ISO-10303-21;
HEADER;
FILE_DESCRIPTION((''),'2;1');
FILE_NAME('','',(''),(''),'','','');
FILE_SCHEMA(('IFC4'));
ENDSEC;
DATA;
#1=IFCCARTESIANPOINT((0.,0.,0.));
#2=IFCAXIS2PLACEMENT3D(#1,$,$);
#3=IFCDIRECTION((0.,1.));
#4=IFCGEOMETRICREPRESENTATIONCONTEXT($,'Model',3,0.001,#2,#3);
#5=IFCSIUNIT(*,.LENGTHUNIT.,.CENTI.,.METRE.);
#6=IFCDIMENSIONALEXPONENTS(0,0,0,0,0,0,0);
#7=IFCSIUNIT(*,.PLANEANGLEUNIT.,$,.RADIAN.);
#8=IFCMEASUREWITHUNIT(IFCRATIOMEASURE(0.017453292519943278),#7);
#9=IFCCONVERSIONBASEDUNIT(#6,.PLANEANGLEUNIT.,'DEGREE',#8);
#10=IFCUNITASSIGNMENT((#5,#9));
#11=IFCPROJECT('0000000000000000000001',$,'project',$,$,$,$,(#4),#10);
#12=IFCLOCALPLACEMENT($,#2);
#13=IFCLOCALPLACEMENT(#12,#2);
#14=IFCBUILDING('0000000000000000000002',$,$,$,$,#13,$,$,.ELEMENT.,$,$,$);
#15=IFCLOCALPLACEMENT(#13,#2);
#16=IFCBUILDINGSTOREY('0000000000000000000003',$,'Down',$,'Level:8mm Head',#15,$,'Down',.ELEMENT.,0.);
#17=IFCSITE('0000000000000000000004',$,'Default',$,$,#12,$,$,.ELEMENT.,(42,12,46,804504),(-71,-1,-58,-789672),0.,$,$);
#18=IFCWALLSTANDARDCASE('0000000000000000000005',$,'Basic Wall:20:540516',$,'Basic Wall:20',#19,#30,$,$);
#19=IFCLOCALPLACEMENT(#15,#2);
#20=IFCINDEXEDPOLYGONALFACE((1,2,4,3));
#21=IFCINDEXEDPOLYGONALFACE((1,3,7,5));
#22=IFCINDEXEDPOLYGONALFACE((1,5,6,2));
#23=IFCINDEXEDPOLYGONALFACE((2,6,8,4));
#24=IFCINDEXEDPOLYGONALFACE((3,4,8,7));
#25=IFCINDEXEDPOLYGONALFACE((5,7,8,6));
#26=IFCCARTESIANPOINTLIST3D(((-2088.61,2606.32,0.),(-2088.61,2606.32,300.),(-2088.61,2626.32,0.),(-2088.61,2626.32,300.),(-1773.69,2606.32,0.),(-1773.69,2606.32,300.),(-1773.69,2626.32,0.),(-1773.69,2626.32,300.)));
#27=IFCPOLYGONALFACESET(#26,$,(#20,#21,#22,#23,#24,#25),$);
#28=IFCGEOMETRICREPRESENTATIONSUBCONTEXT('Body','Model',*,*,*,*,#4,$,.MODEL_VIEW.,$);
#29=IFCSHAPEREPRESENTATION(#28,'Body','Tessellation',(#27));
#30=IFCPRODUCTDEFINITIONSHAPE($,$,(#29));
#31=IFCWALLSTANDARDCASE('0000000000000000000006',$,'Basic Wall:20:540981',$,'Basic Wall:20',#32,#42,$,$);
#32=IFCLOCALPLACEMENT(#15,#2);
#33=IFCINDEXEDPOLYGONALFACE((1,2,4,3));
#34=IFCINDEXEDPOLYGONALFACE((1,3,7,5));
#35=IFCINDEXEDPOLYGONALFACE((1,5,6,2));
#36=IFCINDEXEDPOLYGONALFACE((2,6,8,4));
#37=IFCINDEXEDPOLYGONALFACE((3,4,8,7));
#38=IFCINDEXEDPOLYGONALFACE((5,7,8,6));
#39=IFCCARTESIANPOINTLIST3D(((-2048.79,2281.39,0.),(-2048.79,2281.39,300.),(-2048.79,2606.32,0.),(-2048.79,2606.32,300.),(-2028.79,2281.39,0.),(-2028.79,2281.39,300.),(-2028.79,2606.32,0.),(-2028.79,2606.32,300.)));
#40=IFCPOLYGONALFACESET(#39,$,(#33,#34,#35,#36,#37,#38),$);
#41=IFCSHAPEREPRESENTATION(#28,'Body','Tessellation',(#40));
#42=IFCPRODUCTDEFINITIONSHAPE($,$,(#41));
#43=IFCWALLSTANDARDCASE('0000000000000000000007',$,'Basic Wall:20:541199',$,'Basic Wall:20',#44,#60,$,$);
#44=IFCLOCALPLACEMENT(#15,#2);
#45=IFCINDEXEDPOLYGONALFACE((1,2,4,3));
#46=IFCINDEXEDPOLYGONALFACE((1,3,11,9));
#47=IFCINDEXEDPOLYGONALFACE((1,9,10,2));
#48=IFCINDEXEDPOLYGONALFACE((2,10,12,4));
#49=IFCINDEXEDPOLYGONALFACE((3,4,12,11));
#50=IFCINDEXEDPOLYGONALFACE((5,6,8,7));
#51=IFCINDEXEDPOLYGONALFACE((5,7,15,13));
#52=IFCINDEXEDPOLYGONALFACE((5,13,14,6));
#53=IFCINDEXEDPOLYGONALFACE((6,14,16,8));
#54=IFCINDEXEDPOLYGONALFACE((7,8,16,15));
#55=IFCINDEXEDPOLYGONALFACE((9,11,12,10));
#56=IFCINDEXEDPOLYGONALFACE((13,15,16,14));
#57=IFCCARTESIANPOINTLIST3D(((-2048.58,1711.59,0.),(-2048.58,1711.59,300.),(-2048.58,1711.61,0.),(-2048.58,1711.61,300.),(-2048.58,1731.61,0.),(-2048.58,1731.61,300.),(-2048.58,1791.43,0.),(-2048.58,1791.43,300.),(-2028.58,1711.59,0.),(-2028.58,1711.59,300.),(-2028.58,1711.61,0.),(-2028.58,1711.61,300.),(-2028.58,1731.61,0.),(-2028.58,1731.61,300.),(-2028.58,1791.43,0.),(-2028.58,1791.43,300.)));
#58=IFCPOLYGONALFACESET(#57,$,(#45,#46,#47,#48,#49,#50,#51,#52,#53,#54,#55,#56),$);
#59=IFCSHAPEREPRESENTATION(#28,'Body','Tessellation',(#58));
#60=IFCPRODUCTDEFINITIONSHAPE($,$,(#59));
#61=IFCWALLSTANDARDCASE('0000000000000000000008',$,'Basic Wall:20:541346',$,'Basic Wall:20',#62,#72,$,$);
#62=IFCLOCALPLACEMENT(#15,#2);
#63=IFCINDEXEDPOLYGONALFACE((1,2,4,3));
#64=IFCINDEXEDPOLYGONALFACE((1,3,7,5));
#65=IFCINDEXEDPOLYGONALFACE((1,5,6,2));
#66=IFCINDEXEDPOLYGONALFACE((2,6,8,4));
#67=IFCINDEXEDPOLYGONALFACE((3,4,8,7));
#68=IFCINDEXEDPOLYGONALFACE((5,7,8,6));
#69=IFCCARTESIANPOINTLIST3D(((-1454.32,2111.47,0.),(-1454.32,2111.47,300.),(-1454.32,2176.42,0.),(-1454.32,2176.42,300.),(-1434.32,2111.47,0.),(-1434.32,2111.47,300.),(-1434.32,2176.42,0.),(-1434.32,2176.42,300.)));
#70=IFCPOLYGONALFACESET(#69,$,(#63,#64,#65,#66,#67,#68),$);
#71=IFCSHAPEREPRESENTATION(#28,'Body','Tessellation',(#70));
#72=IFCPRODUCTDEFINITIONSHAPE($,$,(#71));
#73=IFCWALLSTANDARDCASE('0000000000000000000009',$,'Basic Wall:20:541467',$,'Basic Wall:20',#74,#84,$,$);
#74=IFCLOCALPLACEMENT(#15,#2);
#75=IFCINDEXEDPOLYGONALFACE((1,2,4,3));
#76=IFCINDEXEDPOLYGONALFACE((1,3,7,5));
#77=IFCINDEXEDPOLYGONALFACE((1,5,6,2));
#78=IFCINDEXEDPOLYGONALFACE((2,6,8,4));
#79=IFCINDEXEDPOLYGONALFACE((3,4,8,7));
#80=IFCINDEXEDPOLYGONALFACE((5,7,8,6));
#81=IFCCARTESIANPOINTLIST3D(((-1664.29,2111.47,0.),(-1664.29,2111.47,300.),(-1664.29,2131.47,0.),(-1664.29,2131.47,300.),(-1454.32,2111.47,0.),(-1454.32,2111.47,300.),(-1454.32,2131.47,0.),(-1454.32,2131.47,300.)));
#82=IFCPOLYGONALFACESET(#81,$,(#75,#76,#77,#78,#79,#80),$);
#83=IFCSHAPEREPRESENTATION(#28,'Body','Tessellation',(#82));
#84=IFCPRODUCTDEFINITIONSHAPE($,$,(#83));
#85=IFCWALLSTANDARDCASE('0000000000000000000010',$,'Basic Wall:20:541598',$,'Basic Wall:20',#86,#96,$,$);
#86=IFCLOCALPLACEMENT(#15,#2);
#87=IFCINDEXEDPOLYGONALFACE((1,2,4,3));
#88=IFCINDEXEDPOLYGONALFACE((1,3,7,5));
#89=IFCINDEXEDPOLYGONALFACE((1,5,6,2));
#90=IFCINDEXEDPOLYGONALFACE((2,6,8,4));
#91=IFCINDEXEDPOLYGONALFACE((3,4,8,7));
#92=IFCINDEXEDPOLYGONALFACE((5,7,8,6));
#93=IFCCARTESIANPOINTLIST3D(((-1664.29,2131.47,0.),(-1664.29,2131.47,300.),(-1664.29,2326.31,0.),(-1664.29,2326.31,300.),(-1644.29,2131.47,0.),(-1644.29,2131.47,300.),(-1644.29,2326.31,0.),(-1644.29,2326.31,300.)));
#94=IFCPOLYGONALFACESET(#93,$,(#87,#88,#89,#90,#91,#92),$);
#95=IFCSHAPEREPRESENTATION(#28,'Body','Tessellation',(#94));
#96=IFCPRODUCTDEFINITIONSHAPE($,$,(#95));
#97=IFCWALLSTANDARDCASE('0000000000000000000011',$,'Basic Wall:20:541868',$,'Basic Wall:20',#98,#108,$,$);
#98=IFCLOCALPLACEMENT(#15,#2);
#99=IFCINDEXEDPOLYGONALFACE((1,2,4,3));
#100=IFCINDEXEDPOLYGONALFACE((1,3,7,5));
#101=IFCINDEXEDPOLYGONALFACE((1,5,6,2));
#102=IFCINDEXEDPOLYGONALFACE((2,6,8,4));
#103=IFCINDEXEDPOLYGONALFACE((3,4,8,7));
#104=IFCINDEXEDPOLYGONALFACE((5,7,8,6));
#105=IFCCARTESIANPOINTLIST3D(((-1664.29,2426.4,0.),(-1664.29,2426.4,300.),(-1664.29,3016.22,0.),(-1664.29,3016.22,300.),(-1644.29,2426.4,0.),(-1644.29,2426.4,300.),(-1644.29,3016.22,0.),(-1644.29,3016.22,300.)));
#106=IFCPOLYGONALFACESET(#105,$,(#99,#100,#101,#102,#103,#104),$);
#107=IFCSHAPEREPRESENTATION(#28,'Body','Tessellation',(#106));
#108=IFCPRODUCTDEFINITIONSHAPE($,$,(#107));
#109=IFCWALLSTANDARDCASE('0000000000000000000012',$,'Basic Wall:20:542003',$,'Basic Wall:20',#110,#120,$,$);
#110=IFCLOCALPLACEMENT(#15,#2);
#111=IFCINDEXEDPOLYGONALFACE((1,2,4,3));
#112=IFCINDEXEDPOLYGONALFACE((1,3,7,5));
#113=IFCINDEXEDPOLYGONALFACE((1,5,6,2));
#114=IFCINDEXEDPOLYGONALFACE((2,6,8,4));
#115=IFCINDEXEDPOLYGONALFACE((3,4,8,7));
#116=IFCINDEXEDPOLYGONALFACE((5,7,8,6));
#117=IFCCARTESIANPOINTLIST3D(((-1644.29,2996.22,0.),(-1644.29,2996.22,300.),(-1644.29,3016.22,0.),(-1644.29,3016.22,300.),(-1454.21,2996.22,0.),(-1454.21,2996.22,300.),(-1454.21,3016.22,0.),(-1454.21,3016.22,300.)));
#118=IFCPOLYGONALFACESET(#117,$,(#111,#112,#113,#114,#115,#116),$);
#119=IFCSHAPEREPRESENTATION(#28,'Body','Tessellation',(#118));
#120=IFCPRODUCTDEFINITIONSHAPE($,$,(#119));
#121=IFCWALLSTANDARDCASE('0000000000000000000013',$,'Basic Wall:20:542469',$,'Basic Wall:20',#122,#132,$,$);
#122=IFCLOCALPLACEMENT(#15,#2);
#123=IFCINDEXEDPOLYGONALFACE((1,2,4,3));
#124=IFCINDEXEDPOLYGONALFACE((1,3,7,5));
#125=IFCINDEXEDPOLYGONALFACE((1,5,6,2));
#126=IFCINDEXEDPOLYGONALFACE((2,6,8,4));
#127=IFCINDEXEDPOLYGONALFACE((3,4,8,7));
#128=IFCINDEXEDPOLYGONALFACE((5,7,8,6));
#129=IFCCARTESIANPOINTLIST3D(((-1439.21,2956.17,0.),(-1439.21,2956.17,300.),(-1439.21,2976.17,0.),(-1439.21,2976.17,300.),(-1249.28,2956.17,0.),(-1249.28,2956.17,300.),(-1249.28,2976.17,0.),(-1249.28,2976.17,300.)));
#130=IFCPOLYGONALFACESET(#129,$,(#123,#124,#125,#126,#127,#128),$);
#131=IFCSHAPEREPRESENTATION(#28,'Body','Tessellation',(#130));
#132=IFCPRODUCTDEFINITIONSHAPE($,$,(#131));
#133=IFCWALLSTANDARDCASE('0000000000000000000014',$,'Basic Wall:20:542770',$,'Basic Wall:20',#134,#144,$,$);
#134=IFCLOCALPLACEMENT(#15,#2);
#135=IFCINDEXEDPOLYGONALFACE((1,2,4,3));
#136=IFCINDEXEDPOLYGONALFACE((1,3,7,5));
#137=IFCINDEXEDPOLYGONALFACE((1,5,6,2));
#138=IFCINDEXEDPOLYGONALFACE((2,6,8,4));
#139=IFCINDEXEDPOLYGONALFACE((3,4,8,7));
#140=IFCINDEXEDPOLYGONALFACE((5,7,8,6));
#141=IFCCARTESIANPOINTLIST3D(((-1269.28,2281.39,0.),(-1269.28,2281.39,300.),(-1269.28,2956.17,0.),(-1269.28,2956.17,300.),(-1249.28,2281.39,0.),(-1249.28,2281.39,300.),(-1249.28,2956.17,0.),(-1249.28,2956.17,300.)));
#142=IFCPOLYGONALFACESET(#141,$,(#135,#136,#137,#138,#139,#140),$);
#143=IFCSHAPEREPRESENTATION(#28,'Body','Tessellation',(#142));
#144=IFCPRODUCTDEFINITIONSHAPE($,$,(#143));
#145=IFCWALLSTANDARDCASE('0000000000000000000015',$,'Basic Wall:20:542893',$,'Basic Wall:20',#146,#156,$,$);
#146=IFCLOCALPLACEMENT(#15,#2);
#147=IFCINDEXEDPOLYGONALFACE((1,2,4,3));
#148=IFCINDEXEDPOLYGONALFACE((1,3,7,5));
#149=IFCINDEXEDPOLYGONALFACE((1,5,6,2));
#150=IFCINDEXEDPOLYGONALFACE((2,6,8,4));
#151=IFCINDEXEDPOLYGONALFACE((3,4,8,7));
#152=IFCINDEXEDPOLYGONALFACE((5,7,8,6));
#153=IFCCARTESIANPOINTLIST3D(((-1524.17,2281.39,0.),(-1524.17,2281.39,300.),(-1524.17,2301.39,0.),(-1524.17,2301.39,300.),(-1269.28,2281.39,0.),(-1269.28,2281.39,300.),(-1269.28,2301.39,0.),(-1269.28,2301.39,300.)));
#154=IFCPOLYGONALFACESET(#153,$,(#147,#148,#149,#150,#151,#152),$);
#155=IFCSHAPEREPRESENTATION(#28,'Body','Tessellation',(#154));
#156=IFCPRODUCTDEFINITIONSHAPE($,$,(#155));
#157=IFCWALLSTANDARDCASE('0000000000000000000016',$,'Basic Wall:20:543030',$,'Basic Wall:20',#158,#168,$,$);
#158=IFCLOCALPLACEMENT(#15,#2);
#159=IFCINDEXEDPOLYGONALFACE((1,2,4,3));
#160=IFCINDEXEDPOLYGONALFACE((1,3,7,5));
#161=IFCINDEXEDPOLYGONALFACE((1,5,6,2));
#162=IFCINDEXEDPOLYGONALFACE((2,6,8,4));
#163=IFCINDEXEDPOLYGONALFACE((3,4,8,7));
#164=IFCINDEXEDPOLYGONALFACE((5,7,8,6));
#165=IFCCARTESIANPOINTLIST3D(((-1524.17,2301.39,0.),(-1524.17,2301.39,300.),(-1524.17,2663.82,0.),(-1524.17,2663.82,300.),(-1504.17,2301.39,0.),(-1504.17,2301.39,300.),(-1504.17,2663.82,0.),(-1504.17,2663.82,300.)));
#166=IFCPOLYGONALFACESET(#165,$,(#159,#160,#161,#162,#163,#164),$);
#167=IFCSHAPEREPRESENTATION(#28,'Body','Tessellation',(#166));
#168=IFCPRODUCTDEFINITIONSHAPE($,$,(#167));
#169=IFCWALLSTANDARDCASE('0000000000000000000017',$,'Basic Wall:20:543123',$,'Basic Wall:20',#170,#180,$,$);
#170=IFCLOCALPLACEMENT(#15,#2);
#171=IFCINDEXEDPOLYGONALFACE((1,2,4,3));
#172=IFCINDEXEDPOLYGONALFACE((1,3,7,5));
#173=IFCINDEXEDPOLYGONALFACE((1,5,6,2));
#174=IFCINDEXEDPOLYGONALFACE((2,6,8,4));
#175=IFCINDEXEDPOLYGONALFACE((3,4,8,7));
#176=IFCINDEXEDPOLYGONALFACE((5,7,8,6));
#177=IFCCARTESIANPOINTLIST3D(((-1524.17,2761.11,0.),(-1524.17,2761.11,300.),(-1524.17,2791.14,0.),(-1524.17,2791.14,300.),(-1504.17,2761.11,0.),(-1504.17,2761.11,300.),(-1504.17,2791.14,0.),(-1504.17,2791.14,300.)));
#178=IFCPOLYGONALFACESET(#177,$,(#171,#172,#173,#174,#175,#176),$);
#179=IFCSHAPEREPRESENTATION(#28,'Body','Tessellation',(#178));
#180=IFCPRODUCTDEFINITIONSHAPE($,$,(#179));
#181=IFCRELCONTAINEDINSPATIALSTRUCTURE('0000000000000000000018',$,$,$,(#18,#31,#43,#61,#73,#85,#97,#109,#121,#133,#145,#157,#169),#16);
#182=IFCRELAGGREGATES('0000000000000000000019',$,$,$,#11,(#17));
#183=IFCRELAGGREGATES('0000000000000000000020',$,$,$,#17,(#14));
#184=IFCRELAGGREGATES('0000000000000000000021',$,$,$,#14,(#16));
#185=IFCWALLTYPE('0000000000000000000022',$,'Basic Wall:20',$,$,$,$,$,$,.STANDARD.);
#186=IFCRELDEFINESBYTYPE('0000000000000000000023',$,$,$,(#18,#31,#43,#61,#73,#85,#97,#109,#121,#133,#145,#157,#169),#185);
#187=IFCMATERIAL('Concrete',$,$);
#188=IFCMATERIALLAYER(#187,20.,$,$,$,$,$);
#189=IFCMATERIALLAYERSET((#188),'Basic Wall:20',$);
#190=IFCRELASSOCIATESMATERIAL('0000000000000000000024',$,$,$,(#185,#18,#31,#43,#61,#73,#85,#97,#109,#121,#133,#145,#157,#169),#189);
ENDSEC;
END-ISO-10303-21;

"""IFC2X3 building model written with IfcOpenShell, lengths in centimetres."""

from ifc_helpers import new_model, entity, si_unit, converted_unit, direction, frame, frame_2d, origin, place, context, subcontext, project, spatial, rectangle, extrude, material, layer, layer_set, layer_usage, type_object, element, save


model = new_model("IFC2X3")

# Units and contexts
model_context = context("Model", 3, precision=0.001, world=origin(), true_north=direction((0.0, 1.0)))
body_context = subcontext(model_context, "Body", "Model", "MODEL_VIEW")
ifc_project = project(units=[si_unit("LENGTHUNIT", "METRE", prefix="CENTI"), converted_unit("PLANEANGLEUNIT", "DEGREE", entity("IfcRatioMeasure", 0.017453292519943278), si_unit("PLANEANGLEUNIT", "RADIAN"), dimensions=[0, 0, 0, 0, 0, 0, 0])], contexts=[model_context])

# Site, building, storey
site_placement = place(None, origin())
site = spatial("IfcSite", under=ifc_project, at=site_placement, Name="Default", CompositionType="ELEMENT", RefLatitude=(42, 12, 46, 804504), RefLongitude=(-71, -1, -58, -789672), RefElevation=0.0)
building_placement = place(site_placement, origin())
building = spatial("IfcBuilding", under=site, at=building_placement, CompositionType="ELEMENT")
storey_placement = place(building_placement, origin())
storey = spatial("IfcBuildingStorey", under=building, at=storey_placement, Name="Down", ObjectType="Level:8mm Head", LongName="Down", CompositionType="ELEMENT", Elevation=0.0)

# Shared definitions
ifc_material = material(Name="Concrete")

# Walls
ifc_layer_1 = layer(ifc_material, 20.0)
ifc_layer_set_1 = layer_set([ifc_layer_1], Name="Basic Wall:20")
wall_type_1 = type_object("IfcWallType", Name="Basic Wall:20", PredefinedType="STANDARD", material=ifc_layer_set_1)
ifc_layer_usage_1 = layer_usage(ifc_layer_set_1, "AXIS2", "NEGATIVE", 10.0)
wall_1_placement = place(storey_placement, frame((-1773.69, 2616.32, 0.0), z_axis=(0.0, 0.0, 1.0), x_axis=(-1.0, 0.0, 0.0)))
element("IfcWallStandardCase", 1, at=wall_1_placement, inside=storey, type_object=wall_type_1, material=ifc_layer_usage_1, Name="Basic Wall:20:540516", ObjectType="Basic Wall:20", context=body_context, shape_type="SweptSolid", body=[
    extrude(rectangle(XDim=314.92, YDim=20.0, at=frame_2d((157.46, 0.0), x_axis=(-1.0, 0.0))), origin(), (0.0, 0.0, 1.0), 300.0),
])
ifc_layer_usage_2 = layer_usage(ifc_layer_set_1, "AXIS2", "POSITIVE", -10.0)
wall_2_placement = place(storey_placement, frame((-2038.79, 2606.32, 0.0), z_axis=(0.0, 0.0, 1.0), x_axis=(0.0, -1.0, 0.0)))
element("IfcWallStandardCase", 2, at=wall_2_placement, inside=storey, type_object=wall_type_1, material=ifc_layer_usage_2, Name="Basic Wall:20:540981", ObjectType="Basic Wall:20", context=body_context, shape_type="SweptSolid", body=[
    extrude(rectangle(XDim=324.93, YDim=20.0, at=frame_2d((162.47, 0.0), x_axis=(-1.0, 0.0))), origin(), (0.0, 0.0, 1.0), 300.0),
])

# Wall, opening
ifc_layer_usage_3 = layer_usage(ifc_layer_set_1, "AXIS2", "POSITIVE", -10.0)
wall_3_placement = place(storey_placement, frame((-2038.58, 1791.43, 0.0), z_axis=(0.0, 0.0, 1.0), x_axis=(0.0, -1.0, 0.0)))
wall_3 = element("IfcWallStandardCase", 3, at=wall_3_placement, inside=storey, type_object=wall_type_1, material=ifc_layer_usage_3, Name="Basic Wall:20:541199", ObjectType="Basic Wall:20", context=body_context, shape_type="SweptSolid", body=[
    extrude(rectangle(XDim=79.84, YDim=20.0, at=frame_2d((39.92, 0.0), x_axis=(-1.0, 0.0))), origin(), (0.0, 0.0, 1.0), 300.0),
])
opening_placement = place(storey_placement, frame((-2038.58, 1791.43, 0.0), z_axis=(0.0, 0.0, 1.0), x_axis=(0.0, -1.0, 0.0)))
element("IfcOpeningElement", 4, at=opening_placement, cuts=wall_3, ObjectType="Opening", context=body_context, shape_type="SweptSolid", body=[
    extrude(rectangle(XDim=300.0, YDim=20.0, at=frame_2d((0.0, 0.0), x_axis=(1.0, 0.0))), frame((79.82, 0.0, 150.0), z_axis=(-1.0, 0.0, 0.0), x_axis=(0.0, 0.0, 1.0)), (0.0, 0.0, 1.0), 20.0),
])

# Walls
ifc_layer_usage_4 = layer_usage(ifc_layer_set_1, "AXIS2", "NEGATIVE", 10.0)
wall_4_placement = place(storey_placement, frame((-1444.32, 2176.42, 0.0), z_axis=(0.0, 0.0, 1.0), x_axis=(0.0, -1.0, 0.0)))
element("IfcWallStandardCase", 5, at=wall_4_placement, inside=storey, type_object=wall_type_1, material=ifc_layer_usage_4, Name="Basic Wall:20:541346", ObjectType="Basic Wall:20", context=body_context, shape_type="SweptSolid", body=[
    extrude(rectangle(XDim=64.94, YDim=20.0, at=frame_2d((32.47, 0.0), x_axis=(-1.0, 0.0))), origin(), (0.0, 0.0, 1.0), 300.0),
])
ifc_layer_usage_5 = layer_usage(ifc_layer_set_1, "AXIS2", "NEGATIVE", 10.0)
wall_5_placement = place(storey_placement, frame((-1454.32, 2121.47, 0.0), z_axis=(0.0, 0.0, 1.0), x_axis=(-1.0, 0.0, 0.0)))
element("IfcWallStandardCase", 6, at=wall_5_placement, inside=storey, type_object=wall_type_1, material=ifc_layer_usage_5, Name="Basic Wall:20:541467", ObjectType="Basic Wall:20", context=body_context, shape_type="SweptSolid", body=[
    extrude(rectangle(XDim=209.97, YDim=20.0, at=frame_2d((104.98, 0.0), x_axis=(-1.0, 0.0))), origin(), (0.0, 0.0, 1.0), 300.0),
])
ifc_layer_usage_6 = layer_usage(ifc_layer_set_1, "AXIS2", "NEGATIVE", 10.0)
wall_6_placement = place(storey_placement, frame((-1654.29, 2131.47, 0.0), z_axis=(0.0, 0.0, 1.0), x_axis=(0.0, 1.0, 0.0)))
element("IfcWallStandardCase", 7, at=wall_6_placement, inside=storey, type_object=wall_type_1, material=ifc_layer_usage_6, Name="Basic Wall:20:541598", ObjectType="Basic Wall:20", context=body_context, shape_type="SweptSolid", body=[
    extrude(rectangle(XDim=194.84, YDim=20.0, at=frame_2d((97.42, 0.0), x_axis=(-1.0, 0.0))), origin(), (0.0, 0.0, 1.0), 300.0),
])
ifc_layer_usage_7 = layer_usage(ifc_layer_set_1, "AXIS2", "NEGATIVE", 10.0)
wall_7_placement = place(storey_placement, frame((-1654.29, 2426.4, 0.0), z_axis=(0.0, 0.0, 1.0), x_axis=(0.0, 1.0, 0.0)))
element("IfcWallStandardCase", 8, at=wall_7_placement, inside=storey, type_object=wall_type_1, material=ifc_layer_usage_7, Name="Basic Wall:20:541868", ObjectType="Basic Wall:20", context=body_context, shape_type="SweptSolid", body=[
    extrude(rectangle(XDim=589.82, YDim=20.0, at=frame_2d((294.91, 0.0), x_axis=(-1.0, 0.0))), origin(), (0.0, 0.0, 1.0), 300.0),
])
ifc_layer_usage_8 = layer_usage(ifc_layer_set_1, "AXIS2", "NEGATIVE", 10.0)
wall_8_placement = place(storey_placement, frame((-1644.29, 3006.22, 0.0)))
element("IfcWallStandardCase", 9, at=wall_8_placement, inside=storey, type_object=wall_type_1, material=ifc_layer_usage_8, Name="Basic Wall:20:542003", ObjectType="Basic Wall:20", context=body_context, shape_type="SweptSolid", body=[
    extrude(rectangle(XDim=190.08, YDim=20.0, at=frame_2d((95.04, 0.0), x_axis=(-1.0, 0.0))), origin(), (0.0, 0.0, 1.0), 300.0),
])
ifc_layer_usage_9 = layer_usage(ifc_layer_set_1, "AXIS2", "POSITIVE", -10.0)
wall_9_placement = place(storey_placement, frame((-1439.21, 2966.17, 0.0)))
element("IfcWallStandardCase", 10, at=wall_9_placement, inside=storey, type_object=wall_type_1, material=ifc_layer_usage_9, Name="Basic Wall:20:542469", ObjectType="Basic Wall:20", context=body_context, shape_type="SweptSolid", body=[
    extrude(rectangle(XDim=189.93, YDim=20.0, at=frame_2d((94.97, 0.0), x_axis=(-1.0, 0.0))), origin(), (0.0, 0.0, 1.0), 300.0),
])
ifc_layer_usage_10 = layer_usage(ifc_layer_set_1, "AXIS2", "NEGATIVE", 10.0)
wall_10_placement = place(storey_placement, frame((-1259.28, 2956.17, 0.0), z_axis=(0.0, 0.0, 1.0), x_axis=(0.0, -1.0, 0.0)))
element("IfcWallStandardCase", 11, at=wall_10_placement, inside=storey, type_object=wall_type_1, material=ifc_layer_usage_10, Name="Basic Wall:20:542770", ObjectType="Basic Wall:20", context=body_context, shape_type="SweptSolid", body=[
    extrude(rectangle(XDim=674.78, YDim=20.0, at=frame_2d((337.39, 0.0), x_axis=(-1.0, 0.0))), origin(), (0.0, 0.0, 1.0), 300.0),
])
ifc_layer_usage_11 = layer_usage(ifc_layer_set_1, "AXIS2", "NEGATIVE", 10.0)
wall_11_placement = place(storey_placement, frame((-1269.28, 2291.39, 0.0), z_axis=(0.0, 0.0, 1.0), x_axis=(-1.0, 0.0, 0.0)))
element("IfcWallStandardCase", 12, at=wall_11_placement, inside=storey, type_object=wall_type_1, material=ifc_layer_usage_11, Name="Basic Wall:20:542893", ObjectType="Basic Wall:20", context=body_context, shape_type="SweptSolid", body=[
    extrude(rectangle(XDim=254.89, YDim=20.0, at=frame_2d((127.45, 0.0), x_axis=(-1.0, 0.0))), origin(), (0.0, 0.0, 1.0), 300.0),
])
ifc_layer_usage_12 = layer_usage(ifc_layer_set_1, "AXIS2", "NEGATIVE", 10.0)
wall_12_placement = place(storey_placement, frame((-1514.17, 2301.39, 0.0), z_axis=(0.0, 0.0, 1.0), x_axis=(0.0, 1.0, 0.0)))
element("IfcWallStandardCase", 13, at=wall_12_placement, inside=storey, type_object=wall_type_1, material=ifc_layer_usage_12, Name="Basic Wall:20:543030", ObjectType="Basic Wall:20", context=body_context, shape_type="SweptSolid", body=[
    extrude(rectangle(XDim=362.43, YDim=20.0, at=frame_2d((181.21, 0.0), x_axis=(-1.0, 0.0))), origin(), (0.0, 0.0, 1.0), 300.0),
])
ifc_layer_usage_13 = layer_usage(ifc_layer_set_1, "AXIS2", "NEGATIVE", 10.0)
wall_13_placement = place(storey_placement, frame((-1514.17, 2761.11, 0.0), z_axis=(0.0, 0.0, 1.0), x_axis=(0.0, 1.0, 0.0)))
element("IfcWallStandardCase", 14, at=wall_13_placement, inside=storey, type_object=wall_type_1, material=ifc_layer_usage_13, Name="Basic Wall:20:543123", ObjectType="Basic Wall:20", context=body_context, shape_type="SweptSolid", body=[
    extrude(rectangle(XDim=30.03, YDim=20.0, at=frame_2d((15.01, 0.0), x_axis=(-1.0, 0.0))), origin(), (0.0, 0.0, 1.0), 300.0),
])

save(model, "model.ifc")
